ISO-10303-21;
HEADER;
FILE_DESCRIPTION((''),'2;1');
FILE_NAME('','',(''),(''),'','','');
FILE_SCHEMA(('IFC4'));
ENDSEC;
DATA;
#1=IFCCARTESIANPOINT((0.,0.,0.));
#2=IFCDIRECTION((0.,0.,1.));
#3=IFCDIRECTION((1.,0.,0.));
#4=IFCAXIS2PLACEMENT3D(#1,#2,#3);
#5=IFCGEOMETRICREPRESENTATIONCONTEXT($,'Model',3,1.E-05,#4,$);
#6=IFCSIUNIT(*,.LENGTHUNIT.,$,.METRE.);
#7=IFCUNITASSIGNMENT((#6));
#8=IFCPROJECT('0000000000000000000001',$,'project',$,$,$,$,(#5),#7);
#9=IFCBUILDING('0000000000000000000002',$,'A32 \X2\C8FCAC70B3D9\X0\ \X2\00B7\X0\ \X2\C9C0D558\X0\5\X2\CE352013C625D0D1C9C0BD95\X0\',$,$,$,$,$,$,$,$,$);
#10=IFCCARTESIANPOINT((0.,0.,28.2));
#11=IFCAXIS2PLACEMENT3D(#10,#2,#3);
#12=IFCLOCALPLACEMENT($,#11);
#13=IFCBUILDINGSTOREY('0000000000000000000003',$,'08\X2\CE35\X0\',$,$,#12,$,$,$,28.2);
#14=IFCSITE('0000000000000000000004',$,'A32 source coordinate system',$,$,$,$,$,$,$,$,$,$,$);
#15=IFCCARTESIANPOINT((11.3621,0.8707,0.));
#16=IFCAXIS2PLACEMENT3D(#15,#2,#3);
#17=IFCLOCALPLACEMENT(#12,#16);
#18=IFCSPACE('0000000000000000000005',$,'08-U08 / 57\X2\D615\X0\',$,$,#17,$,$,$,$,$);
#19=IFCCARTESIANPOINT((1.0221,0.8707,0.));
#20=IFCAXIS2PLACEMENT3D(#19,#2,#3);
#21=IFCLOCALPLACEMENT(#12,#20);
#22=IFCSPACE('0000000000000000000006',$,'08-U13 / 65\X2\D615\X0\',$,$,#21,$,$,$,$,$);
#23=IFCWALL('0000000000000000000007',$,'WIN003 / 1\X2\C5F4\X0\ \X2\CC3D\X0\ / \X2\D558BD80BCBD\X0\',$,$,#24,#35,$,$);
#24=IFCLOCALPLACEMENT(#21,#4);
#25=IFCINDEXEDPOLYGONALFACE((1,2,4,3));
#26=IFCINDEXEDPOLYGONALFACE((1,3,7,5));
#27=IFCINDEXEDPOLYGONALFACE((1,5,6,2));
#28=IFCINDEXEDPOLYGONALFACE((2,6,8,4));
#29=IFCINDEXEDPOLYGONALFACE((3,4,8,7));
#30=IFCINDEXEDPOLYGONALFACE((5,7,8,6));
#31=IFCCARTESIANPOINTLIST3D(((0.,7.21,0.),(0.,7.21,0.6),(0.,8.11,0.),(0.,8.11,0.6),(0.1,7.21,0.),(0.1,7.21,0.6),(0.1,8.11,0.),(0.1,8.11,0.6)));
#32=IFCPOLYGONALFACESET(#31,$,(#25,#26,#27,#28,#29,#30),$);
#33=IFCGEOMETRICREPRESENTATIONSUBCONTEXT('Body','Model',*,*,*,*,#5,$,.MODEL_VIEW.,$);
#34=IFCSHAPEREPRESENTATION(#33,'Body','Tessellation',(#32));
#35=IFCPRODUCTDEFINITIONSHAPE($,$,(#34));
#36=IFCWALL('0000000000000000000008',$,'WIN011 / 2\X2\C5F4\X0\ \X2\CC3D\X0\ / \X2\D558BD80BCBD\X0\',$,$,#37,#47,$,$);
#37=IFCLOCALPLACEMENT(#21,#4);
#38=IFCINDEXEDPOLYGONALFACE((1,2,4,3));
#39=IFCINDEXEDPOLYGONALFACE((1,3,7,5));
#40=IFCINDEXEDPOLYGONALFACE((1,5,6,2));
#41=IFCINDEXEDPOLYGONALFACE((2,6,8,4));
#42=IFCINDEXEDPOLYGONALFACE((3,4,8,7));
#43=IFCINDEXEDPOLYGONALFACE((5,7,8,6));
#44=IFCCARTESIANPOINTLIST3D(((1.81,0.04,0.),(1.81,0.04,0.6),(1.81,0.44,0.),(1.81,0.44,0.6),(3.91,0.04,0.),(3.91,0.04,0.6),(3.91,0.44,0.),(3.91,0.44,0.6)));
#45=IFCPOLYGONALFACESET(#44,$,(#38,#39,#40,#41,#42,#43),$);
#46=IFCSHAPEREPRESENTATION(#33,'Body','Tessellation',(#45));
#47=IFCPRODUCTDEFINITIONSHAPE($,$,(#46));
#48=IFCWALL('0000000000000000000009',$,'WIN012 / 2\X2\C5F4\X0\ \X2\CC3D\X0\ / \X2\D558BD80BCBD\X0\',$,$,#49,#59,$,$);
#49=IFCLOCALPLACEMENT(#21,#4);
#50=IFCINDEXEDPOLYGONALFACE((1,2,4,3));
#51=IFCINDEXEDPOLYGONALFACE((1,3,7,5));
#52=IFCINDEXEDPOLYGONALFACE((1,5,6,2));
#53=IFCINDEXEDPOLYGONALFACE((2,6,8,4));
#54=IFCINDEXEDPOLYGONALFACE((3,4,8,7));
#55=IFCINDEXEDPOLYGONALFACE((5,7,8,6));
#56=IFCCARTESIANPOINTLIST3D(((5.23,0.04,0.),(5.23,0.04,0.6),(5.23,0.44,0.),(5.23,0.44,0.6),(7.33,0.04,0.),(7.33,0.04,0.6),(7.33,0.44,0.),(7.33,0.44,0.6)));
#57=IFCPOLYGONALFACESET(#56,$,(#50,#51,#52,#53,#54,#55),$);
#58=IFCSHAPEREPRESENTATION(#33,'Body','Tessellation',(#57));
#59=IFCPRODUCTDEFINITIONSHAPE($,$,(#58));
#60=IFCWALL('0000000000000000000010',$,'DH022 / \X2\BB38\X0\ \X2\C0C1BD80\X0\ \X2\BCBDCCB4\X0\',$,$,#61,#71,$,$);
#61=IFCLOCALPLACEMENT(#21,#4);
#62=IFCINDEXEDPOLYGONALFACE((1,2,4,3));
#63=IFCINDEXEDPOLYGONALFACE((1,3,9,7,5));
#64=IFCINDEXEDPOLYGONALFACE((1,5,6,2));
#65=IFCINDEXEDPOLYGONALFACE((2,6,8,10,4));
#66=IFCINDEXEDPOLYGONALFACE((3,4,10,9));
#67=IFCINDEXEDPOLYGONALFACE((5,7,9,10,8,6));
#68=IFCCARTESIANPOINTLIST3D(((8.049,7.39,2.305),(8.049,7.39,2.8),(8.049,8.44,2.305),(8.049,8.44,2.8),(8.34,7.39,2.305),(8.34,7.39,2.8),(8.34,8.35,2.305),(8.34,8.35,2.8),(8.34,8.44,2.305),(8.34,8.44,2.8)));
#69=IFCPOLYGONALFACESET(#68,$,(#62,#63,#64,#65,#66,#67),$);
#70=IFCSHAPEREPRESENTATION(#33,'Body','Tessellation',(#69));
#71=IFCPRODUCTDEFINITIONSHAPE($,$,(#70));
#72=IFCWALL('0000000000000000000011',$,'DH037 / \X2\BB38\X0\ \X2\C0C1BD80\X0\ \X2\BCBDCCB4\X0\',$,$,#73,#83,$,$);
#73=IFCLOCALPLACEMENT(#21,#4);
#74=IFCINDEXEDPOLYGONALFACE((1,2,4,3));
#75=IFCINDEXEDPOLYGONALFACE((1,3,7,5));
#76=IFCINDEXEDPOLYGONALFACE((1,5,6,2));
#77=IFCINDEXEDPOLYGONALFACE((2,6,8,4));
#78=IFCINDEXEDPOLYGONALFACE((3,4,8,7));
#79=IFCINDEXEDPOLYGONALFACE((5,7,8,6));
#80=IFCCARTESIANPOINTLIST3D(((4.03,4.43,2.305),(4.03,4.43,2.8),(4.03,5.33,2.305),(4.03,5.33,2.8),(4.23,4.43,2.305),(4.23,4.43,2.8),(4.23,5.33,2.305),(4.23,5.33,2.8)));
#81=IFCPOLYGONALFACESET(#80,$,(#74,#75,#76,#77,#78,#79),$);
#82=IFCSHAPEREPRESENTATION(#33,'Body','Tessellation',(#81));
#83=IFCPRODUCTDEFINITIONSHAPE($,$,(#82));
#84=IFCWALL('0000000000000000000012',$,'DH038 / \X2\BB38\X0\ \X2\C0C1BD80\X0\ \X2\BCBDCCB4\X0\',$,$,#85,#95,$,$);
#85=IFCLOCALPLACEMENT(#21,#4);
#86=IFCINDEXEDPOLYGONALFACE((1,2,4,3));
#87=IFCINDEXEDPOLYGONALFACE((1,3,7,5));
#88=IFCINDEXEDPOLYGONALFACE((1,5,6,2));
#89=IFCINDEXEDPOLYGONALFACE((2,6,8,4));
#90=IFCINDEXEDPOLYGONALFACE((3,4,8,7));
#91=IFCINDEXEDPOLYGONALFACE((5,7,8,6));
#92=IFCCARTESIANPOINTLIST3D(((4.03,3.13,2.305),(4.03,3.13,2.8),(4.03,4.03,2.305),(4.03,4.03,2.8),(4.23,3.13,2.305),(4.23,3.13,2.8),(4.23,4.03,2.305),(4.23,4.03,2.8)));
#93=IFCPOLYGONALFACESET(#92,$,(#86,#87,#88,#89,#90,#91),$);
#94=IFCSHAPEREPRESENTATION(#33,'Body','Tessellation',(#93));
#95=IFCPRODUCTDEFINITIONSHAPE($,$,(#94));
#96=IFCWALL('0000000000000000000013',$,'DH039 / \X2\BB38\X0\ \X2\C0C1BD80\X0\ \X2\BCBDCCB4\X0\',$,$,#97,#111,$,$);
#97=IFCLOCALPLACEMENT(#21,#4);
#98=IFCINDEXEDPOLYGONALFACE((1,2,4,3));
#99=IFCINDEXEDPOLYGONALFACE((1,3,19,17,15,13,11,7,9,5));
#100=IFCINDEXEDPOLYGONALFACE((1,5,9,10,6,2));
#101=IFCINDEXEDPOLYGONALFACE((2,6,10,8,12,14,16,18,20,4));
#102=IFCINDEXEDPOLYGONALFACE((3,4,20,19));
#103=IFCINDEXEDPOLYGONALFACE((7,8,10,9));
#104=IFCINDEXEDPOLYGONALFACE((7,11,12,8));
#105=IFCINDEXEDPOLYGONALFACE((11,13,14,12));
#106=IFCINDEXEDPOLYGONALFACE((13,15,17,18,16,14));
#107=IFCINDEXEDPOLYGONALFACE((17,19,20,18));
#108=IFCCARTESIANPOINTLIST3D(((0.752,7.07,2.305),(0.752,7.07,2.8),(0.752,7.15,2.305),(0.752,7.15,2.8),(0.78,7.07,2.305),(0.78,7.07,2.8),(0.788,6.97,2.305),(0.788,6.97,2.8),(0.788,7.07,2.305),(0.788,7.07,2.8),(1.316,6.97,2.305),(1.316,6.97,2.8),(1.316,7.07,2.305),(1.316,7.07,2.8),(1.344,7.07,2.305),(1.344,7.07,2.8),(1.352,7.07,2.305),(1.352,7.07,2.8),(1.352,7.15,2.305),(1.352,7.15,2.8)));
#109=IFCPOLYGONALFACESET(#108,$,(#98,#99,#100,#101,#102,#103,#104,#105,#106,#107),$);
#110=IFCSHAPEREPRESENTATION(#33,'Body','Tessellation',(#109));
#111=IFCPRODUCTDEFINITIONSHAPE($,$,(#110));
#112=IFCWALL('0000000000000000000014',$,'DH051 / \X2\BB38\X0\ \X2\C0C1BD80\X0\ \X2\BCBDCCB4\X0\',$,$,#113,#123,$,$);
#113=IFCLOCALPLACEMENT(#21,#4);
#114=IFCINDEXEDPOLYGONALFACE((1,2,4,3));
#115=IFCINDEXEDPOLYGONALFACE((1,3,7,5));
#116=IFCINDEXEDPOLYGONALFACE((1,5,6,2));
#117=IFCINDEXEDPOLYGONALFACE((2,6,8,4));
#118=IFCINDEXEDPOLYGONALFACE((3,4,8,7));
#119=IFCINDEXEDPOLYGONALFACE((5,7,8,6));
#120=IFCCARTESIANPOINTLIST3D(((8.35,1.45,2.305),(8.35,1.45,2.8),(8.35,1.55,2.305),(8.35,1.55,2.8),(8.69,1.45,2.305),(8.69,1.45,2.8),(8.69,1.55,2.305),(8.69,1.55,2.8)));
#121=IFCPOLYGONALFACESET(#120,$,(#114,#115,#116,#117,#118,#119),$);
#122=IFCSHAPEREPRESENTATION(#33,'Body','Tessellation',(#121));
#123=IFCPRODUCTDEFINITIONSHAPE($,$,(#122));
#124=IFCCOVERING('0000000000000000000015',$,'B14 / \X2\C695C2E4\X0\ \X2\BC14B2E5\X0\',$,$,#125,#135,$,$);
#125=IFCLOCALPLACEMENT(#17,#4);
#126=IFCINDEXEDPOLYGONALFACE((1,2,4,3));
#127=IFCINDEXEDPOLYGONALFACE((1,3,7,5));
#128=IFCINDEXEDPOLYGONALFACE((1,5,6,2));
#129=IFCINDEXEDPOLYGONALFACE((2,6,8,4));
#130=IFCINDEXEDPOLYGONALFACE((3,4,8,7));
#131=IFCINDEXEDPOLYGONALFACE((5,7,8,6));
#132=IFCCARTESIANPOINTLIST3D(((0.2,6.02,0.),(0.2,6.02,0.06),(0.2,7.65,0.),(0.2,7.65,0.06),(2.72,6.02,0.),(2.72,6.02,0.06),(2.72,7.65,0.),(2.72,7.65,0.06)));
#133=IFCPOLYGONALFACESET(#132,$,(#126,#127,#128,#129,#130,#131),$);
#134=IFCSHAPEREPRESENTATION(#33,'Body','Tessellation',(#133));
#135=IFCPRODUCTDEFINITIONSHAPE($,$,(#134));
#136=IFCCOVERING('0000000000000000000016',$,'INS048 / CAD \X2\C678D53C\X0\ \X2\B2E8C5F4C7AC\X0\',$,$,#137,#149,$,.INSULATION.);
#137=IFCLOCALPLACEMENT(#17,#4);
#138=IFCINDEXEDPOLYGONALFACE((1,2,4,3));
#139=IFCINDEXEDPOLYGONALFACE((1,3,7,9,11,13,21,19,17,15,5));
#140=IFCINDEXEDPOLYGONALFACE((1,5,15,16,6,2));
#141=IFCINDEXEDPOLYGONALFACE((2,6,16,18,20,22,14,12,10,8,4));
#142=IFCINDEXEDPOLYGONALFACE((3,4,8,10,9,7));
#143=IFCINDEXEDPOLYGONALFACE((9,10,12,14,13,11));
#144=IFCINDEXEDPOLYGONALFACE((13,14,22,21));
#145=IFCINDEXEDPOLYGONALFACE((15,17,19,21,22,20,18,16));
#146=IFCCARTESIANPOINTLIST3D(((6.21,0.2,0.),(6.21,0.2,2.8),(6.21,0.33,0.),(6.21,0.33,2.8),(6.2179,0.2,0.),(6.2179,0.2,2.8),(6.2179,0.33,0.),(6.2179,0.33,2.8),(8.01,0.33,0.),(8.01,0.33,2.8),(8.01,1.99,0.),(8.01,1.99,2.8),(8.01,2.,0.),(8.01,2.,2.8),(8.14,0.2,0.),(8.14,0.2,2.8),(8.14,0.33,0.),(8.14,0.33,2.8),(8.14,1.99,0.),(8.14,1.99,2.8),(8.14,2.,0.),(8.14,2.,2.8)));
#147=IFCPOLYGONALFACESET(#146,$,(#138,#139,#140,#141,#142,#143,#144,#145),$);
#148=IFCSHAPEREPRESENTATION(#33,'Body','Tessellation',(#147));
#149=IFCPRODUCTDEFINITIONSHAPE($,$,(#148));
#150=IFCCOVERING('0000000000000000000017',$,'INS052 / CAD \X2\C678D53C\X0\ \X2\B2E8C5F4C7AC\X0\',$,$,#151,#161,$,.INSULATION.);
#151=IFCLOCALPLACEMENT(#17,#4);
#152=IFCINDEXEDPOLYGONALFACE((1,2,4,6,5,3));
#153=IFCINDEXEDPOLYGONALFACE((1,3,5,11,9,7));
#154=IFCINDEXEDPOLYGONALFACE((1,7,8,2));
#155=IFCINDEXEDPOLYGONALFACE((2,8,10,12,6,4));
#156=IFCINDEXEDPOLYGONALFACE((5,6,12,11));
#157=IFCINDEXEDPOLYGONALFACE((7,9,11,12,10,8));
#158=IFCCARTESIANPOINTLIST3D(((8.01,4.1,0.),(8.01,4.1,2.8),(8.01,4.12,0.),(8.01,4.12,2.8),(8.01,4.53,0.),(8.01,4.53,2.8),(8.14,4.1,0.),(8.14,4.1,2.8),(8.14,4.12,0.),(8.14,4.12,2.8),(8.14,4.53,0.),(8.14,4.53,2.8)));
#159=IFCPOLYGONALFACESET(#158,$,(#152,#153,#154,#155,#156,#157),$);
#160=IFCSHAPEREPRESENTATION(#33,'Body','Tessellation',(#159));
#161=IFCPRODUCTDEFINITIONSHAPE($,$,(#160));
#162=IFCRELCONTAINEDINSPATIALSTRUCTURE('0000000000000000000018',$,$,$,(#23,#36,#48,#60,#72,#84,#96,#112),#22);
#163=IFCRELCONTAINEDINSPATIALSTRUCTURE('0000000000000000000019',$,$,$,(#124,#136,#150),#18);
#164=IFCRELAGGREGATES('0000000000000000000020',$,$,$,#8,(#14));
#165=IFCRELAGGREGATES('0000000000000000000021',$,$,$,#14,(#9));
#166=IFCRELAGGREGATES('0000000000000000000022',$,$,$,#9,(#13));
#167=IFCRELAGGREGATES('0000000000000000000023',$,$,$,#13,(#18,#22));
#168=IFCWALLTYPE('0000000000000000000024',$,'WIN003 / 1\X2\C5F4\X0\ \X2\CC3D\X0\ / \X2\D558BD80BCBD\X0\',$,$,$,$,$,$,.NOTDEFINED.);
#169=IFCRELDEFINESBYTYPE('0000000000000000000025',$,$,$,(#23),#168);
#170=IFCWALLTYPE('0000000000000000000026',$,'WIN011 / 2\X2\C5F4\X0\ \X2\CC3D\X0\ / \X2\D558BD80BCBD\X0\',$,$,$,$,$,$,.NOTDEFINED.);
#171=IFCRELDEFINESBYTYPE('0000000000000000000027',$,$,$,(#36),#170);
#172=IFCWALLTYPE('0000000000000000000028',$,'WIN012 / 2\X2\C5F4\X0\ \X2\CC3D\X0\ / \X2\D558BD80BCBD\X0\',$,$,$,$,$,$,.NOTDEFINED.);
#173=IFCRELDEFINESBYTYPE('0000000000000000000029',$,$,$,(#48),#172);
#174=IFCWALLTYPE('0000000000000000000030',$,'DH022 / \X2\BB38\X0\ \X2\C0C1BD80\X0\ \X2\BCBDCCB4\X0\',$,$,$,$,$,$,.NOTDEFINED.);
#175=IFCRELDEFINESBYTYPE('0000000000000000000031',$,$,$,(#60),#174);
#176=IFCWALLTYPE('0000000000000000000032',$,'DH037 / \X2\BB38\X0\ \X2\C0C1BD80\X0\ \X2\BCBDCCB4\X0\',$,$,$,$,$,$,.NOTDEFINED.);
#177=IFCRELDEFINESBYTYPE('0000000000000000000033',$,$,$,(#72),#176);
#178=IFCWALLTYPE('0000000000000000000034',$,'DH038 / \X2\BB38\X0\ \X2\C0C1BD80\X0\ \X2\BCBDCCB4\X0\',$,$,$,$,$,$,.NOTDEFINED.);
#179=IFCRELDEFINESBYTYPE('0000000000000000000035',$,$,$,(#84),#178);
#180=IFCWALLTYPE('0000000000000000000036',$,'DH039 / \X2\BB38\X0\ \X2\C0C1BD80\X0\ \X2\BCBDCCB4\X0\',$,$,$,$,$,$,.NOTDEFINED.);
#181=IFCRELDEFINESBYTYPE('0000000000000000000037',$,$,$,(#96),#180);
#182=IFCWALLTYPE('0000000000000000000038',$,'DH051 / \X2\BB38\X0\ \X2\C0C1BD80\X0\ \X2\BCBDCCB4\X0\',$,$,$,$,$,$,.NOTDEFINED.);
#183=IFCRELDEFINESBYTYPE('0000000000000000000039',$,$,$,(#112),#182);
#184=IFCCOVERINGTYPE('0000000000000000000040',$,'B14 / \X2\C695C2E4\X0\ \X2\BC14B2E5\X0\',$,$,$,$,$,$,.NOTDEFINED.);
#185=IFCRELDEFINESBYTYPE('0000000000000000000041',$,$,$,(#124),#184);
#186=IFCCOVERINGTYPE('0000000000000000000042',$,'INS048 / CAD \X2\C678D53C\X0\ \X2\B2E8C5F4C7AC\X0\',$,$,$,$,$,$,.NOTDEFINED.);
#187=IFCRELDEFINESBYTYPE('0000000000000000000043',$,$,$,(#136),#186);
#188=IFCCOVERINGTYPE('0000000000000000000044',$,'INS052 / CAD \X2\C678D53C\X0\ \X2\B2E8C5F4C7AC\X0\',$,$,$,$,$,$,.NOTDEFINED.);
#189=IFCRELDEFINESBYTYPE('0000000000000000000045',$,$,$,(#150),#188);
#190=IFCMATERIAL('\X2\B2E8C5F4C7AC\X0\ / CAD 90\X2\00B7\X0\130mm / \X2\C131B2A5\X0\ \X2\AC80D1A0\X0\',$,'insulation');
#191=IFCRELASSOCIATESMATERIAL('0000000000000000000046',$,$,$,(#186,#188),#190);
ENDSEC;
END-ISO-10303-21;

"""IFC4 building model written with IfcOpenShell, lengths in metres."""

from ifc_helpers import new_model, si_unit, frame, origin, origin_with_axes, place, context, subcontext, project, spatial, polyline, outline, extrude, source, transform, mapped, material, type_object, type_shapes, element, save


model = new_model("IFC4")

# Units and contexts
model_context = context("Model", 3, precision=1e-05, world=origin_with_axes())
body_context = subcontext(model_context, "Body", "Model", "MODEL_VIEW")
ifc_project = project(units=[si_unit("LENGTHUNIT", "METRE")], contexts=[model_context])

# Site, building, storey, space
site = spatial("IfcSite", under=ifc_project, Name="A32 source coordinate system")
building = spatial("IfcBuilding", under=site, Name="A32 주거동 · 지하5층–옥탑지붕")
storey_placement = place(None, frame((0.0, 0.0, 28.2), z_axis=(0.0, 0.0, 1.0), x_axis=(1.0, 0.0, 0.0)))
storey = spatial("IfcBuildingStorey", under=building, at=storey_placement, Name="08층", Elevation=28.2)
space_1_placement = place(storey_placement, frame((11.3621, 0.8707, 0.0), z_axis=(0.0, 0.0, 1.0), x_axis=(1.0, 0.0, 0.0)))
space_1 = spatial("IfcSpace", under=storey, at=space_1_placement, Name="08-U08 / 57형")

# Shared definitions
space_2_placement = place(storey_placement, frame((1.0221, 0.8707, 0.0), z_axis=(0.0, 0.0, 1.0), x_axis=(1.0, 0.0, 0.0)))
space_2 = spatial("IfcSpace", under=storey, at=space_2_placement, Name="08-U13 / 65형")

# Walls
wall_type_1 = type_object("IfcWallType", Name="WIN003 / 1열 창 / 하부벽", PredefinedType="NOTDEFINED")
shared_shape_1 = source(origin(), body_context, "Body", "SweptSolid", [
    extrude(outline(polyline([(0.0, 8.11), (0.1, 8.11), (0.1, 7.21), (0.0, 7.21), (0.0, 8.11)])), origin(), (0.0, 0.0, 1.0), 0.6),
])
type_shapes(wall_type_1, [shared_shape_1])
wall_1_placement = place(space_2_placement, origin_with_axes())
element("IfcWall", 1, at=wall_1_placement, inside=space_2, type_object=wall_type_1, Name="WIN003 / 1열 창 / 하부벽", context=body_context, shape_type="MappedRepresentation", body=[
    mapped(shared_shape_1, transform((0.0, 0.0, 0.0), scale=1.0)),
])
wall_type_2 = type_object("IfcWallType", Name="WIN011 / 2열 창 / 하부벽", PredefinedType="NOTDEFINED")
shared_shape_2 = source(origin(), body_context, "Body", "SweptSolid", [
    extrude(outline(polyline([(1.81, 0.44), (3.91, 0.44), (3.91, 0.04), (1.81, 0.04), (1.81, 0.44)])), origin(), (0.0, 0.0, 1.0), 0.6),
])
type_shapes(wall_type_2, [shared_shape_2])
wall_2_placement = place(space_2_placement, origin_with_axes())
element("IfcWall", 2, at=wall_2_placement, inside=space_2, type_object=wall_type_2, Name="WIN011 / 2열 창 / 하부벽", context=body_context, shape_type="MappedRepresentation", body=[
    mapped(shared_shape_2, transform((0.0, 0.0, 0.0), scale=1.0)),
])
wall_type_3 = type_object("IfcWallType", Name="WIN012 / 2열 창 / 하부벽", PredefinedType="NOTDEFINED")
shared_shape_3 = source(origin(), body_context, "Body", "SweptSolid", [
    extrude(outline(polyline([(5.23, 0.44), (7.33, 0.44), (7.33, 0.04), (5.23, 0.04), (5.23, 0.44)])), origin(), (0.0, 0.0, 1.0), 0.6),
])
type_shapes(wall_type_3, [shared_shape_3])
wall_3_placement = place(space_2_placement, origin_with_axes())
element("IfcWall", 3, at=wall_3_placement, inside=space_2, type_object=wall_type_3, Name="WIN012 / 2열 창 / 하부벽", context=body_context, shape_type="MappedRepresentation", body=[
    mapped(shared_shape_3, transform((0.0, 0.0, 0.0), scale=1.0)),
])
wall_type_4 = type_object("IfcWallType", Name="DH022 / 문 상부 벽체", PredefinedType="NOTDEFINED")
shared_shape_4 = source(origin(), body_context, "Body", "SweptSolid", [
    extrude(outline(polyline([(8.049, 7.39), (8.049, 8.44), (8.34, 8.44), (8.34, 8.35), (8.34, 8.35), (8.34, 7.39), (8.049, 7.39)])), frame((0.0, 0.0, 2.305)), (0.0, 0.0, 1.0), 0.495),
])
type_shapes(wall_type_4, [shared_shape_4])
wall_4_placement = place(space_2_placement, origin_with_axes())
element("IfcWall", 4, at=wall_4_placement, inside=space_2, type_object=wall_type_4, Name="DH022 / 문 상부 벽체", context=body_context, shape_type="MappedRepresentation", body=[
    mapped(shared_shape_4, transform((0.0, 0.0, 0.0), scale=1.0)),
])
wall_type_5 = type_object("IfcWallType", Name="DH037 / 문 상부 벽체", PredefinedType="NOTDEFINED")
shared_shape_5 = source(origin(), body_context, "Body", "SweptSolid", [
    extrude(outline(polyline([(4.23, 5.33), (4.23, 4.43), (4.03, 4.43), (4.03, 5.33), (4.23, 5.33)])), frame((0.0, 0.0, 2.305)), (0.0, 0.0, 1.0), 0.495),
])
type_shapes(wall_type_5, [shared_shape_5])
wall_5_placement = place(space_2_placement, origin_with_axes())
element("IfcWall", 5, at=wall_5_placement, inside=space_2, type_object=wall_type_5, Name="DH037 / 문 상부 벽체", context=body_context, shape_type="MappedRepresentation", body=[
    mapped(shared_shape_5, transform((0.0, 0.0, 0.0), scale=1.0)),
])
wall_type_6 = type_object("IfcWallType", Name="DH038 / 문 상부 벽체", PredefinedType="NOTDEFINED")
shared_shape_6 = source(origin(), body_context, "Body", "SweptSolid", [
    extrude(outline(polyline([(4.23, 4.03), (4.23, 3.13), (4.03, 3.13), (4.03, 4.03), (4.23, 4.03)])), frame((0.0, 0.0, 2.305)), (0.0, 0.0, 1.0), 0.495),
])
type_shapes(wall_type_6, [shared_shape_6])
wall_6_placement = place(space_2_placement, origin_with_axes())
element("IfcWall", 6, at=wall_6_placement, inside=space_2, type_object=wall_type_6, Name="DH038 / 문 상부 벽체", context=body_context, shape_type="MappedRepresentation", body=[
    mapped(shared_shape_6, transform((0.0, 0.0, 0.0), scale=1.0)),
])
wall_type_7 = type_object("IfcWallType", Name="DH039 / 문 상부 벽체", PredefinedType="NOTDEFINED")
shared_shape_7 = source(origin(), body_context, "Body", "SweptSolid", [
    extrude(outline(polyline([(1.316, 7.07), (1.316, 6.97), (0.788, 6.97), (0.788, 7.07), (0.78, 7.07), (0.752, 7.07), (0.752, 7.15), (1.352, 7.15), (1.352, 7.07), (1.344, 7.07), (1.316, 7.07)])), frame((0.0, 0.0, 2.305)), (0.0, 0.0, 1.0), 0.495),
])
type_shapes(wall_type_7, [shared_shape_7])
wall_7_placement = place(space_2_placement, origin_with_axes())
element("IfcWall", 7, at=wall_7_placement, inside=space_2, type_object=wall_type_7, Name="DH039 / 문 상부 벽체", context=body_context, shape_type="MappedRepresentation", body=[
    mapped(shared_shape_7, transform((0.0, 0.0, 0.0), scale=1.0)),
])
wall_type_8 = type_object("IfcWallType", Name="DH051 / 문 상부 벽체", PredefinedType="NOTDEFINED")
shared_shape_8 = source(origin(), body_context, "Body", "SweptSolid", [
    extrude(outline(polyline([(8.69, 1.55), (8.69, 1.45), (8.35, 1.45), (8.35, 1.55), (8.69, 1.55)])), frame((0.0, 0.0, 2.305)), (0.0, 0.0, 1.0), 0.495),
])
type_shapes(wall_type_8, [shared_shape_8])
wall_8_placement = place(space_2_placement, origin_with_axes())
element("IfcWall", 8, at=wall_8_placement, inside=space_2, type_object=wall_type_8, Name="DH051 / 문 상부 벽체", context=body_context, shape_type="MappedRepresentation", body=[
    mapped(shared_shape_8, transform((0.0, 0.0, 0.0), scale=1.0)),
])

# Coverings
covering_type_1 = type_object("IfcCoveringType", Name="B14 / 욕실 바닥", PredefinedType="NOTDEFINED")
shared_shape_9 = source(origin(), body_context, "Body", "SweptSolid", [
    extrude(outline(polyline([(0.2, 7.65), (2.72, 7.65), (2.72, 6.02), (0.2, 6.02), (0.2, 7.65)])), origin(), (0.0, 0.0, 1.0), 0.06),
])
type_shapes(covering_type_1, [shared_shape_9])
covering_1_placement = place(space_1_placement, origin_with_axes())
element("IfcCovering", 9, at=covering_1_placement, inside=space_1, type_object=covering_type_1, Name="B14 / 욕실 바닥", context=body_context, shape_type="MappedRepresentation", body=[
    mapped(shared_shape_9, transform((0.0, 0.0, 0.0), scale=1.0)),
])
ifc_material = material(Name="단열재 / CAD 90·130mm / 성능 검토", Category="insulation")
covering_type_2 = type_object("IfcCoveringType", Name="INS048 / CAD 외피 단열재", PredefinedType="NOTDEFINED", material=ifc_material)
shared_shape_10 = source(origin(), body_context, "Body", "SweptSolid", [
    extrude(outline(polyline([(8.01, 1.99), (8.01, 2.0), (8.14, 2.0), (8.14, 1.99), (8.14, 0.33), (8.14, 0.2), (6.2179, 0.2), (6.21, 0.2), (6.21, 0.33), (6.2179, 0.33), (8.01, 0.33), (8.01, 1.99)])), origin(), (0.0, 0.0, 1.0), 2.8),
])
type_shapes(covering_type_2, [shared_shape_10])
covering_2_placement = place(space_1_placement, origin_with_axes())
element("IfcCovering", 10, at=covering_2_placement, inside=space_1, type_object=covering_type_2, Name="INS048 / CAD 외피 단열재", PredefinedType="INSULATION", context=body_context, shape_type="MappedRepresentation", body=[
    mapped(shared_shape_10, transform((0.0, 0.0, 0.0), scale=1.0)),
])
covering_type_3 = type_object("IfcCoveringType", Name="INS052 / CAD 외피 단열재", PredefinedType="NOTDEFINED", material=ifc_material)
shared_shape_11 = source(origin(), body_context, "Body", "SweptSolid", [
    extrude(outline(polyline([(8.14, 4.1), (8.01, 4.1), (8.01, 4.12), (8.01, 4.53), (8.14, 4.53), (8.14, 4.12), (8.14, 4.1)])), origin(), (0.0, 0.0, 1.0), 2.8),
])
type_shapes(covering_type_3, [shared_shape_11])
covering_3_placement = place(space_1_placement, origin_with_axes())
element("IfcCovering", 11, at=covering_3_placement, inside=space_1, type_object=covering_type_3, Name="INS052 / CAD 외피 단열재", PredefinedType="INSULATION", context=body_context, shape_type="MappedRepresentation", body=[
    mapped(shared_shape_11, transform((0.0, 0.0, 0.0), scale=1.0)),
])

save(model, "model.ifc")
